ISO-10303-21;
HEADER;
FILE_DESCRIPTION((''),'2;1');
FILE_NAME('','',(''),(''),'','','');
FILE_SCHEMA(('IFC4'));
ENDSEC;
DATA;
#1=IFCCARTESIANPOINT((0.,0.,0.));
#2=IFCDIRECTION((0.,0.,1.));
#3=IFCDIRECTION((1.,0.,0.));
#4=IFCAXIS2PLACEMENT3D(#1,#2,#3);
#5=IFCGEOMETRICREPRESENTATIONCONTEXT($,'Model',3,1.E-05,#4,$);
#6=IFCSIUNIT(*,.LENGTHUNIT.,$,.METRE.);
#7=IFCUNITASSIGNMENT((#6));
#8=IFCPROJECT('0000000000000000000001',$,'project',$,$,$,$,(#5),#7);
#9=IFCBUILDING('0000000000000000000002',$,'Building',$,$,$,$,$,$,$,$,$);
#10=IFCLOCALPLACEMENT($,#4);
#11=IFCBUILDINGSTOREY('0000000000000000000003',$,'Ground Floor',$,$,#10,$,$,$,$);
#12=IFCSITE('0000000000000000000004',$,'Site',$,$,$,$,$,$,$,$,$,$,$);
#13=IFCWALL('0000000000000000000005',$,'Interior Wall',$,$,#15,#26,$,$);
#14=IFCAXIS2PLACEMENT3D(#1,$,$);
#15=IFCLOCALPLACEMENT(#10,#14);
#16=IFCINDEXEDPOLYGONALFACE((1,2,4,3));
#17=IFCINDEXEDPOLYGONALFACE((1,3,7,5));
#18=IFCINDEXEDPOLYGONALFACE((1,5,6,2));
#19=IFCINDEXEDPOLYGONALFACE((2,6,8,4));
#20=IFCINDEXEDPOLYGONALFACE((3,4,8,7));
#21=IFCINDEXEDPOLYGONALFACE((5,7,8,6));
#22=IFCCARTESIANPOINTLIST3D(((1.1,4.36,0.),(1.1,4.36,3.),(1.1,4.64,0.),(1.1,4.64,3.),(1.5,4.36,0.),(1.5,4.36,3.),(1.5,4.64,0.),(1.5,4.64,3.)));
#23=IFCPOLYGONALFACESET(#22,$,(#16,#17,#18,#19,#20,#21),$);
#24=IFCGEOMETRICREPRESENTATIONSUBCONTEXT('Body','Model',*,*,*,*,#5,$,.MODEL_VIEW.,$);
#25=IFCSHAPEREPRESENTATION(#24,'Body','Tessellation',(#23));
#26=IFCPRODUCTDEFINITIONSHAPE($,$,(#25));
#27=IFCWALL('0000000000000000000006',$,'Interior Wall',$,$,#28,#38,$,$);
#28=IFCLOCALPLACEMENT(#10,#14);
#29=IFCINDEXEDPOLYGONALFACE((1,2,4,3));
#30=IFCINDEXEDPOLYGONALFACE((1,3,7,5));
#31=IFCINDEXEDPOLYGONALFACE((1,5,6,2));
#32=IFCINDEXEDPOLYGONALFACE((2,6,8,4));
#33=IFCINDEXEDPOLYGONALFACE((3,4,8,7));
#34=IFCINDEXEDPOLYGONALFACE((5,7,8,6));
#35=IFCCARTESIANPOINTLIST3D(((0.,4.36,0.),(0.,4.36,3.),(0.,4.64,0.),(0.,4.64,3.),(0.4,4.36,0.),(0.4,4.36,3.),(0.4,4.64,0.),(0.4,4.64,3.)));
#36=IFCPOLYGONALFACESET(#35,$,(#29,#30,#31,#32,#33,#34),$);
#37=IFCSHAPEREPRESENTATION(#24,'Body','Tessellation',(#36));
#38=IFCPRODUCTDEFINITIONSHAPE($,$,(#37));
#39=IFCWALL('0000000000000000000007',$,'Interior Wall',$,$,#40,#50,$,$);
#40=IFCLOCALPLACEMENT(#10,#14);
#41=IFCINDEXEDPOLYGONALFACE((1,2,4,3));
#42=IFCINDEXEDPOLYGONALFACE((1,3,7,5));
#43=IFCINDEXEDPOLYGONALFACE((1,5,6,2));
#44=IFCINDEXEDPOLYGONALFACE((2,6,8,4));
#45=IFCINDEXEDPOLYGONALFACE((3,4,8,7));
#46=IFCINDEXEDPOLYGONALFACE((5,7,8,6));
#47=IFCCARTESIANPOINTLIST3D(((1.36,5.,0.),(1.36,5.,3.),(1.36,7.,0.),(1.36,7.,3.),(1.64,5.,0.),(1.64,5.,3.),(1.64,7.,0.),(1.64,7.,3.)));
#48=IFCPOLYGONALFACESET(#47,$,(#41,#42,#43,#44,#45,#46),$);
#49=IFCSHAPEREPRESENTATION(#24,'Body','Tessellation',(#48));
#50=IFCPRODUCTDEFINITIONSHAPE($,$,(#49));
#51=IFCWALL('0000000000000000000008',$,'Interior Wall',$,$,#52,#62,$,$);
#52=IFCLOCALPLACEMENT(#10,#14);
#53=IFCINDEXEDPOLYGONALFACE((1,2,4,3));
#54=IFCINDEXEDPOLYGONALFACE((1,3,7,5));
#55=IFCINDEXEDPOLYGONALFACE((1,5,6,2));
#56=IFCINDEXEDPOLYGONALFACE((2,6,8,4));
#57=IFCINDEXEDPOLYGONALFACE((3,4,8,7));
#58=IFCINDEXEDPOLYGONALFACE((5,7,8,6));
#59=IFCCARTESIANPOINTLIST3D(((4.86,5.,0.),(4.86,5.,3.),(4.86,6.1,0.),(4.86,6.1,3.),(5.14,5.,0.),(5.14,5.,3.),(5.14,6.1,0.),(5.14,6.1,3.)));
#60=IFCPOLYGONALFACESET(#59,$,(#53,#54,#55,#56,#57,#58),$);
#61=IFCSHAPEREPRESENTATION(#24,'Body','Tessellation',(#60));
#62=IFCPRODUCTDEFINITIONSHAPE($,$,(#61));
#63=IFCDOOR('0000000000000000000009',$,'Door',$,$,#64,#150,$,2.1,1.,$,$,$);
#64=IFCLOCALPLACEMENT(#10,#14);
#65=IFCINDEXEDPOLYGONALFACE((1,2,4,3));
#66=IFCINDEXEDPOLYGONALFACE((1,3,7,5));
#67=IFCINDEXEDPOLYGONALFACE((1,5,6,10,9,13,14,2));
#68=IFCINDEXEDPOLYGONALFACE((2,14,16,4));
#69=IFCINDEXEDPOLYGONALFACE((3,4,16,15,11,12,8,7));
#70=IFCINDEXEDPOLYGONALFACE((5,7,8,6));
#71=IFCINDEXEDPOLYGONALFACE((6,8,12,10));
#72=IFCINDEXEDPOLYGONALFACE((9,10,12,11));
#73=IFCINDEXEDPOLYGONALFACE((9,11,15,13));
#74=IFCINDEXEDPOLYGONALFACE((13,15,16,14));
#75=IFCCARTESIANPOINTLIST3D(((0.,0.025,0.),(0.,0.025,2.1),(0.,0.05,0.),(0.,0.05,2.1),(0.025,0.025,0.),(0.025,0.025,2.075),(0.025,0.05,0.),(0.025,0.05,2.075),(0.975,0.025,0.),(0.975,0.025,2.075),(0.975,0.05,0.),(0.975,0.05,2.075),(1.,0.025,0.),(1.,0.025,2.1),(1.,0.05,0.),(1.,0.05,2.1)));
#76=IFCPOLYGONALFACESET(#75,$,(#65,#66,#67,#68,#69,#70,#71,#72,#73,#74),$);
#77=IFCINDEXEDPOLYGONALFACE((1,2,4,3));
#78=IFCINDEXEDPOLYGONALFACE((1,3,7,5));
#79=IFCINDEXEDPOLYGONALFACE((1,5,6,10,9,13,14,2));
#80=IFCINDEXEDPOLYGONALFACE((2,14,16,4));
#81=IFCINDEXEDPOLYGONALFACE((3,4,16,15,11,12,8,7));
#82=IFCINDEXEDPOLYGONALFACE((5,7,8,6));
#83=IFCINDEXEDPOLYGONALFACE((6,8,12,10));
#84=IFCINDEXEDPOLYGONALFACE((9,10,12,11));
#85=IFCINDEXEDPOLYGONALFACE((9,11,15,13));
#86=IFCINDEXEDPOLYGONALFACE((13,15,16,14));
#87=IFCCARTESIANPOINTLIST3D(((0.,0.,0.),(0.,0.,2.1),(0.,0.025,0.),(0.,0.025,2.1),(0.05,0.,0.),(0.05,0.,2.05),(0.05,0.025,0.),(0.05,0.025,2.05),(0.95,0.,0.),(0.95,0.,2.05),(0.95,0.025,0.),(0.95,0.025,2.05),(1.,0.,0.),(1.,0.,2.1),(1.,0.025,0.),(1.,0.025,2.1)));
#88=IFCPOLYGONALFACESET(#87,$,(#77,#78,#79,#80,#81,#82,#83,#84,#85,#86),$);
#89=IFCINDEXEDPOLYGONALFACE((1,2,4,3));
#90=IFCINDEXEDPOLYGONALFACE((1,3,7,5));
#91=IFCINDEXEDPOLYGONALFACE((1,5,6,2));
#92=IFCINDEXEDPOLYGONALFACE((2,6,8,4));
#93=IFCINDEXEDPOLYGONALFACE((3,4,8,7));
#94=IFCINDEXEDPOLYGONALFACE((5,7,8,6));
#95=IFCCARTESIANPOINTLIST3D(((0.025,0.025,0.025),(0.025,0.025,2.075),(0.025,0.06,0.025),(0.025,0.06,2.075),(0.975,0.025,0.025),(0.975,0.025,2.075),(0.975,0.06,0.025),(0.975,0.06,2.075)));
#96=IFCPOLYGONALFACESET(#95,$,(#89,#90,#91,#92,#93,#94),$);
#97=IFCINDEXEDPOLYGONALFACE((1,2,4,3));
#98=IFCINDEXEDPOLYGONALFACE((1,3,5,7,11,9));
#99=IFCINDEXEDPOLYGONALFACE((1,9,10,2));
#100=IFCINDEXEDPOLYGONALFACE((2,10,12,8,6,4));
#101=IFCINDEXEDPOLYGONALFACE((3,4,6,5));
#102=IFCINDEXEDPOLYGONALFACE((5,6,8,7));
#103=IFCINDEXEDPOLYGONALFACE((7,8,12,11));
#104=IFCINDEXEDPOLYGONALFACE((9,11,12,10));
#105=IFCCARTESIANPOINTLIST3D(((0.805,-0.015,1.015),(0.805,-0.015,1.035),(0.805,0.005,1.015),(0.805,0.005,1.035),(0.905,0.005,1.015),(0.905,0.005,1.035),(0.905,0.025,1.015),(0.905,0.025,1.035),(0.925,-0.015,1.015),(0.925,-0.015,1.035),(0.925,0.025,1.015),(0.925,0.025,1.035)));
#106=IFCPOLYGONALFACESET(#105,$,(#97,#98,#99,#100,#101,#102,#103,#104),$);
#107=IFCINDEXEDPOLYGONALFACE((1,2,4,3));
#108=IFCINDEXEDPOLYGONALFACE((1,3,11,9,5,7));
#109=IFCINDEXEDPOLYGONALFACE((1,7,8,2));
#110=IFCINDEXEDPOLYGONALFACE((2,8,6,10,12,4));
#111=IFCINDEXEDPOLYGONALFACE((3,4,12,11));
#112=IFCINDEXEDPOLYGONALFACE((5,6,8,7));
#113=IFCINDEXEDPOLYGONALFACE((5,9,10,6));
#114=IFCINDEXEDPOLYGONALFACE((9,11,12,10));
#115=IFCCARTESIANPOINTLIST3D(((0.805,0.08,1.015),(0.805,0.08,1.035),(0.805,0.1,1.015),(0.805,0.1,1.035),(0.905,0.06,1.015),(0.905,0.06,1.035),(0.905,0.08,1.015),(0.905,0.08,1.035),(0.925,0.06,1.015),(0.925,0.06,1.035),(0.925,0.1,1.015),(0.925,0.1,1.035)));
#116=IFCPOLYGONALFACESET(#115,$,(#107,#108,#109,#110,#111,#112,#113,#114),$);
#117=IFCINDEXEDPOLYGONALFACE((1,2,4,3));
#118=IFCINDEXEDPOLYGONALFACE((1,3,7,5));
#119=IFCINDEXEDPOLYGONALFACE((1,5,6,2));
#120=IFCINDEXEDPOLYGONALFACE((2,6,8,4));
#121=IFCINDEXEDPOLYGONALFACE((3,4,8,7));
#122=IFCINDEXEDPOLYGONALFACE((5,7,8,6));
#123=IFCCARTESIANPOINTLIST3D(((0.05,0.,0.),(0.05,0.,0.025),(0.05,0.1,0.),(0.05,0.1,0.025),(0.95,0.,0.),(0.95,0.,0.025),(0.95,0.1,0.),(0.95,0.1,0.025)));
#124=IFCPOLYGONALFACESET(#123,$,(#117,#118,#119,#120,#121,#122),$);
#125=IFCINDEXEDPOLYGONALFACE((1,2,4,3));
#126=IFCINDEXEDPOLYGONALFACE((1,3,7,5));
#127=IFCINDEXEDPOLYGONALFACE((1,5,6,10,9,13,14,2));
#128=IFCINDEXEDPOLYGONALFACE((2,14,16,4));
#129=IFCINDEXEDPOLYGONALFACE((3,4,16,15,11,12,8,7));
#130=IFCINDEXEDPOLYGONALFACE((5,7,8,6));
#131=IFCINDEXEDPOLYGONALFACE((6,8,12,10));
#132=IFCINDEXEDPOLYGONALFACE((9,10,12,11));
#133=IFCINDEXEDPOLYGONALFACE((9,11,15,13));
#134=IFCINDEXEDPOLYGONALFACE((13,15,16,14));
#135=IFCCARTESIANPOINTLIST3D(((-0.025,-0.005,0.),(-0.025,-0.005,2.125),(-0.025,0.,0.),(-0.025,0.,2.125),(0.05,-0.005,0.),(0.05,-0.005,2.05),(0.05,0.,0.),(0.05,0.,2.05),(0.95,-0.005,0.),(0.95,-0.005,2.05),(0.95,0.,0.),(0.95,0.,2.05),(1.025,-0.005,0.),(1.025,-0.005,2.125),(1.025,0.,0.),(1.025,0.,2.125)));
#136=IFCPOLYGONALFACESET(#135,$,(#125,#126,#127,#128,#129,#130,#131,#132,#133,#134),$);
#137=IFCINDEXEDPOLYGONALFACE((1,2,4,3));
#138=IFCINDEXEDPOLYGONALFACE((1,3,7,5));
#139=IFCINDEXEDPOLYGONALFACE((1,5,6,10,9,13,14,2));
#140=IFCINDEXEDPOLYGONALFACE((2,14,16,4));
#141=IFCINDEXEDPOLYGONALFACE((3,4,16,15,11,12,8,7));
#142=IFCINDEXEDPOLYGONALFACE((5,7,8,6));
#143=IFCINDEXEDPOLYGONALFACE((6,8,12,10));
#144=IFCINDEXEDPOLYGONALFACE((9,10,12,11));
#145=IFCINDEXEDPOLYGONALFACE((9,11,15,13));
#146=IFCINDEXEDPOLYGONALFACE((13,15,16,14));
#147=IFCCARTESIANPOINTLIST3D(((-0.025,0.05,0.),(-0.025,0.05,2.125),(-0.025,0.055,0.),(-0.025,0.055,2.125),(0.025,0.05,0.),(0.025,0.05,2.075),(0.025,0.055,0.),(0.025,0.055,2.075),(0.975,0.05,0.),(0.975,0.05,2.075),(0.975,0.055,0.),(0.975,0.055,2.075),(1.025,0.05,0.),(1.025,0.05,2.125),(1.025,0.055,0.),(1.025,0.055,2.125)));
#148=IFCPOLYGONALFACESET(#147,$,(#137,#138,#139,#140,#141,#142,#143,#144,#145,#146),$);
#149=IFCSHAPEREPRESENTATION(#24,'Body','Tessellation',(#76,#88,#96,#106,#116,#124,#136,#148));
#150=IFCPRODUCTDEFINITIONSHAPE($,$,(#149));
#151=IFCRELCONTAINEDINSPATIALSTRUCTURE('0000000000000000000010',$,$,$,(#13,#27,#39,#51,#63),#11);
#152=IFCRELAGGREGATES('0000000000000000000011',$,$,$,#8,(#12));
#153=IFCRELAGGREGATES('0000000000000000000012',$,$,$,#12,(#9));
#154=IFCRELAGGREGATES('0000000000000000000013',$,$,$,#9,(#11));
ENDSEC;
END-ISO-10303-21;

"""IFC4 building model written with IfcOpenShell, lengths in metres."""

from ifc_helpers import new_model, si_unit, frame, origin_with_axes, place, context, subcontext, project, spatial, line, indexed_curve, outline, extrude, element, save


model = new_model("IFC4")

# Units and contexts
model_context = context("Model", 3, precision=1e-05, world=origin_with_axes())
body_context = subcontext(model_context, "Body", "Model", "MODEL_VIEW")
ifc_project = project(units=[si_unit("LENGTHUNIT", "METRE")], contexts=[model_context])

# Site, building, storey
site = spatial("IfcSite", under=ifc_project, Name="Site")
building = spatial("IfcBuilding", under=site, Name="Building")
storey_placement = place(None, origin_with_axes())
storey = spatial("IfcBuildingStorey", under=building, at=storey_placement, Name="Ground Floor")

# Walls
for number, where, z_axis, x_axis, name in (
    (1, (1.5, 4.5, 0.0), (0.0, 0.0, 1.0), (-1.0, 0.0, 0.0), "Interior Wall"),
    (2, (0.4, 4.5, 0.0), (0.0, 0.0, 1.0), (-1.0, 0.0, 0.0), "Interior Wall"),
):
    element("IfcWall", number, at=place(storey_placement, frame(where, z_axis=z_axis, x_axis=x_axis)), inside=storey, Name=name, context=body_context, shape_type="SweptSolid", body=[
        extrude(outline(indexed_curve([(0.0, 0.0), (0.0, 0.28), (0.4, 0.28), (0.4, 0.0), (0.0, 0.0)], self_intersect=False)), frame((0.0, -0.14, 0.0), z_axis=(0.0, 0.0, 1.0), x_axis=(1.0, 0.0, 0.0)), (0.0, 0.0, 1.0), 3.0),
    ])
wall_1_placement = place(storey_placement, frame((1.5, 5.0, 0.0), z_axis=(0.0, 0.0, 1.0), x_axis=(0.0, 1.0, 0.0)))
element("IfcWall", 3, at=wall_1_placement, inside=storey, Name="Interior Wall", context=body_context, shape_type="SweptSolid", body=[
    extrude(outline(indexed_curve([(0.0, 0.0), (0.0, 0.28), (2.0, 0.28), (2.0, 0.0), (0.0, 0.0)], self_intersect=False)), frame((0.0, -0.14, 0.0), z_axis=(0.0, 0.0, 1.0), x_axis=(1.0, 0.0, 0.0)), (0.0, 0.0, 1.0), 3.0),
])
wall_2_placement = place(storey_placement, frame((5.0, 5.0, 0.0), z_axis=(0.0, 0.0, 1.0), x_axis=(0.0, 1.0, 0.0)))
element("IfcWall", 4, at=wall_2_placement, inside=storey, Name="Interior Wall", context=body_context, shape_type="SweptSolid", body=[
    extrude(outline(indexed_curve([(0.0, 0.0), (0.0, 0.28), (1.1, 0.28), (1.1, 0.0), (0.0, 0.0)], self_intersect=False)), frame((0.0, -0.14, 0.0), z_axis=(0.0, 0.0, 1.0), x_axis=(1.0, 0.0, 0.0)), (0.0, 0.0, 1.0), 3.0),
])

# Door
door_1_placement = place(storey_placement, origin_with_axes())
element("IfcDoor", 5, at=door_1_placement, inside=storey, Name="Door", OverallHeight=2.1, OverallWidth=1.0, context=body_context, shape_type="SweptSolid", body=[
    extrude(outline(indexed_curve([(0.0, 0.0), (0.0, 2.1), (1.0, 2.1), (1.0, 0.0), (0.975, 0.0), (0.975, 2.075), (0.025, 2.075), (0.025, 0.0)], segments=[line(1, 2, 3, 4, 5, 6, 7, 8, 1)])), frame((0.0, 0.025, 0.0), z_axis=(0.0, -1.0, 0.0), x_axis=(1.0, 0.0, 0.0)), (0.0, 0.0, -1.0), 0.025),
    extrude(outline(indexed_curve([(0.0, 0.0), (0.0, 2.1), (1.0, 2.1), (1.0, 0.0), (0.95, 0.0), (0.95, 2.05), (0.05, 2.05), (0.05, 0.0)], segments=[line(1, 2, 3, 4, 5, 6, 7, 8, 1)])), frame((0.0, 0.0, 0.0), z_axis=(0.0, -1.0, 0.0), x_axis=(1.0, 0.0, 0.0)), (0.0, 0.0, -1.0), 0.025),
    extrude(outline(indexed_curve([(0.0, 0.0), (0.95, 0.0), (0.95, 0.035), (0.0, 0.035)], segments=[line(1, 2, 3, 4, 1)])), frame((0.025, 0.025, 0.025), z_axis=(0.0, 0.0, 1.0), x_axis=(1.0, 0.0, 0.0)), (0.0, 0.0, 1.0), 2.05),
    extrude(outline(indexed_curve([(0.0, 0.0), (0.0, -0.04), (-0.12, -0.04), (-0.12, -0.02), (-0.02, -0.02), (-0.02, 0.0)], segments=[line(1, 2, 3, 4, 5, 6, 1)])), frame((0.925, 0.025, 1.015), z_axis=(0.0, 0.0, 1.0), x_axis=(1.0, 0.0, 0.0)), (0.0, 0.0, 1.0), 0.02),
    extrude(outline(indexed_curve([(0.0, 0.0), (0.0, 0.04), (-0.12, 0.04), (-0.12, 0.02), (-0.02, 0.02), (-0.02, 0.0)], segments=[line(1, 2, 3, 4, 5, 6, 1)])), frame((0.925, 0.06, 1.015), z_axis=(0.0, 0.0, 1.0), x_axis=(1.0, 0.0, 0.0)), (0.0, 0.0, 1.0), 0.02),
    extrude(outline(indexed_curve([(0.0, 0.0), (0.9, 0.0), (0.9, 0.1), (0.0, 0.1)], segments=[line(1, 2, 3, 4, 1)])), frame((0.05, 0.0, 0.0), z_axis=(0.0, 0.0, 1.0), x_axis=(1.0, 0.0, 0.0)), (0.0, 0.0, 1.0), 0.025),
    extrude(outline(indexed_curve([(0.0, 0.0), (0.0, 2.125), (1.05, 2.125), (1.05, 0.0), (0.975, 0.0), (0.975, 2.05), (0.075, 2.05), (0.075, 0.0)], segments=[line(1, 2, 3, 4, 5, 6, 7, 8, 1)])), frame((-0.025, -0.005, 0.0), z_axis=(0.0, -1.0, 0.0), x_axis=(1.0, 0.0, 0.0)), (0.0, 0.0, -1.0), 0.005),
    extrude(outline(indexed_curve([(0.0, 0.0), (0.0, 2.125), (1.05, 2.125), (1.05, 0.0), (1.0, 0.0), (1.0, 2.075), (0.05, 2.075), (0.05, 0.0)], segments=[line(1, 2, 3, 4, 5, 6, 7, 8, 1)])), frame((-0.025, 0.05, 0.0), z_axis=(0.0, -1.0, 0.0), x_axis=(1.0, 0.0, 0.0)), (0.0, 0.0, -1.0), 0.005),
])

save(model, "model.ifc")
